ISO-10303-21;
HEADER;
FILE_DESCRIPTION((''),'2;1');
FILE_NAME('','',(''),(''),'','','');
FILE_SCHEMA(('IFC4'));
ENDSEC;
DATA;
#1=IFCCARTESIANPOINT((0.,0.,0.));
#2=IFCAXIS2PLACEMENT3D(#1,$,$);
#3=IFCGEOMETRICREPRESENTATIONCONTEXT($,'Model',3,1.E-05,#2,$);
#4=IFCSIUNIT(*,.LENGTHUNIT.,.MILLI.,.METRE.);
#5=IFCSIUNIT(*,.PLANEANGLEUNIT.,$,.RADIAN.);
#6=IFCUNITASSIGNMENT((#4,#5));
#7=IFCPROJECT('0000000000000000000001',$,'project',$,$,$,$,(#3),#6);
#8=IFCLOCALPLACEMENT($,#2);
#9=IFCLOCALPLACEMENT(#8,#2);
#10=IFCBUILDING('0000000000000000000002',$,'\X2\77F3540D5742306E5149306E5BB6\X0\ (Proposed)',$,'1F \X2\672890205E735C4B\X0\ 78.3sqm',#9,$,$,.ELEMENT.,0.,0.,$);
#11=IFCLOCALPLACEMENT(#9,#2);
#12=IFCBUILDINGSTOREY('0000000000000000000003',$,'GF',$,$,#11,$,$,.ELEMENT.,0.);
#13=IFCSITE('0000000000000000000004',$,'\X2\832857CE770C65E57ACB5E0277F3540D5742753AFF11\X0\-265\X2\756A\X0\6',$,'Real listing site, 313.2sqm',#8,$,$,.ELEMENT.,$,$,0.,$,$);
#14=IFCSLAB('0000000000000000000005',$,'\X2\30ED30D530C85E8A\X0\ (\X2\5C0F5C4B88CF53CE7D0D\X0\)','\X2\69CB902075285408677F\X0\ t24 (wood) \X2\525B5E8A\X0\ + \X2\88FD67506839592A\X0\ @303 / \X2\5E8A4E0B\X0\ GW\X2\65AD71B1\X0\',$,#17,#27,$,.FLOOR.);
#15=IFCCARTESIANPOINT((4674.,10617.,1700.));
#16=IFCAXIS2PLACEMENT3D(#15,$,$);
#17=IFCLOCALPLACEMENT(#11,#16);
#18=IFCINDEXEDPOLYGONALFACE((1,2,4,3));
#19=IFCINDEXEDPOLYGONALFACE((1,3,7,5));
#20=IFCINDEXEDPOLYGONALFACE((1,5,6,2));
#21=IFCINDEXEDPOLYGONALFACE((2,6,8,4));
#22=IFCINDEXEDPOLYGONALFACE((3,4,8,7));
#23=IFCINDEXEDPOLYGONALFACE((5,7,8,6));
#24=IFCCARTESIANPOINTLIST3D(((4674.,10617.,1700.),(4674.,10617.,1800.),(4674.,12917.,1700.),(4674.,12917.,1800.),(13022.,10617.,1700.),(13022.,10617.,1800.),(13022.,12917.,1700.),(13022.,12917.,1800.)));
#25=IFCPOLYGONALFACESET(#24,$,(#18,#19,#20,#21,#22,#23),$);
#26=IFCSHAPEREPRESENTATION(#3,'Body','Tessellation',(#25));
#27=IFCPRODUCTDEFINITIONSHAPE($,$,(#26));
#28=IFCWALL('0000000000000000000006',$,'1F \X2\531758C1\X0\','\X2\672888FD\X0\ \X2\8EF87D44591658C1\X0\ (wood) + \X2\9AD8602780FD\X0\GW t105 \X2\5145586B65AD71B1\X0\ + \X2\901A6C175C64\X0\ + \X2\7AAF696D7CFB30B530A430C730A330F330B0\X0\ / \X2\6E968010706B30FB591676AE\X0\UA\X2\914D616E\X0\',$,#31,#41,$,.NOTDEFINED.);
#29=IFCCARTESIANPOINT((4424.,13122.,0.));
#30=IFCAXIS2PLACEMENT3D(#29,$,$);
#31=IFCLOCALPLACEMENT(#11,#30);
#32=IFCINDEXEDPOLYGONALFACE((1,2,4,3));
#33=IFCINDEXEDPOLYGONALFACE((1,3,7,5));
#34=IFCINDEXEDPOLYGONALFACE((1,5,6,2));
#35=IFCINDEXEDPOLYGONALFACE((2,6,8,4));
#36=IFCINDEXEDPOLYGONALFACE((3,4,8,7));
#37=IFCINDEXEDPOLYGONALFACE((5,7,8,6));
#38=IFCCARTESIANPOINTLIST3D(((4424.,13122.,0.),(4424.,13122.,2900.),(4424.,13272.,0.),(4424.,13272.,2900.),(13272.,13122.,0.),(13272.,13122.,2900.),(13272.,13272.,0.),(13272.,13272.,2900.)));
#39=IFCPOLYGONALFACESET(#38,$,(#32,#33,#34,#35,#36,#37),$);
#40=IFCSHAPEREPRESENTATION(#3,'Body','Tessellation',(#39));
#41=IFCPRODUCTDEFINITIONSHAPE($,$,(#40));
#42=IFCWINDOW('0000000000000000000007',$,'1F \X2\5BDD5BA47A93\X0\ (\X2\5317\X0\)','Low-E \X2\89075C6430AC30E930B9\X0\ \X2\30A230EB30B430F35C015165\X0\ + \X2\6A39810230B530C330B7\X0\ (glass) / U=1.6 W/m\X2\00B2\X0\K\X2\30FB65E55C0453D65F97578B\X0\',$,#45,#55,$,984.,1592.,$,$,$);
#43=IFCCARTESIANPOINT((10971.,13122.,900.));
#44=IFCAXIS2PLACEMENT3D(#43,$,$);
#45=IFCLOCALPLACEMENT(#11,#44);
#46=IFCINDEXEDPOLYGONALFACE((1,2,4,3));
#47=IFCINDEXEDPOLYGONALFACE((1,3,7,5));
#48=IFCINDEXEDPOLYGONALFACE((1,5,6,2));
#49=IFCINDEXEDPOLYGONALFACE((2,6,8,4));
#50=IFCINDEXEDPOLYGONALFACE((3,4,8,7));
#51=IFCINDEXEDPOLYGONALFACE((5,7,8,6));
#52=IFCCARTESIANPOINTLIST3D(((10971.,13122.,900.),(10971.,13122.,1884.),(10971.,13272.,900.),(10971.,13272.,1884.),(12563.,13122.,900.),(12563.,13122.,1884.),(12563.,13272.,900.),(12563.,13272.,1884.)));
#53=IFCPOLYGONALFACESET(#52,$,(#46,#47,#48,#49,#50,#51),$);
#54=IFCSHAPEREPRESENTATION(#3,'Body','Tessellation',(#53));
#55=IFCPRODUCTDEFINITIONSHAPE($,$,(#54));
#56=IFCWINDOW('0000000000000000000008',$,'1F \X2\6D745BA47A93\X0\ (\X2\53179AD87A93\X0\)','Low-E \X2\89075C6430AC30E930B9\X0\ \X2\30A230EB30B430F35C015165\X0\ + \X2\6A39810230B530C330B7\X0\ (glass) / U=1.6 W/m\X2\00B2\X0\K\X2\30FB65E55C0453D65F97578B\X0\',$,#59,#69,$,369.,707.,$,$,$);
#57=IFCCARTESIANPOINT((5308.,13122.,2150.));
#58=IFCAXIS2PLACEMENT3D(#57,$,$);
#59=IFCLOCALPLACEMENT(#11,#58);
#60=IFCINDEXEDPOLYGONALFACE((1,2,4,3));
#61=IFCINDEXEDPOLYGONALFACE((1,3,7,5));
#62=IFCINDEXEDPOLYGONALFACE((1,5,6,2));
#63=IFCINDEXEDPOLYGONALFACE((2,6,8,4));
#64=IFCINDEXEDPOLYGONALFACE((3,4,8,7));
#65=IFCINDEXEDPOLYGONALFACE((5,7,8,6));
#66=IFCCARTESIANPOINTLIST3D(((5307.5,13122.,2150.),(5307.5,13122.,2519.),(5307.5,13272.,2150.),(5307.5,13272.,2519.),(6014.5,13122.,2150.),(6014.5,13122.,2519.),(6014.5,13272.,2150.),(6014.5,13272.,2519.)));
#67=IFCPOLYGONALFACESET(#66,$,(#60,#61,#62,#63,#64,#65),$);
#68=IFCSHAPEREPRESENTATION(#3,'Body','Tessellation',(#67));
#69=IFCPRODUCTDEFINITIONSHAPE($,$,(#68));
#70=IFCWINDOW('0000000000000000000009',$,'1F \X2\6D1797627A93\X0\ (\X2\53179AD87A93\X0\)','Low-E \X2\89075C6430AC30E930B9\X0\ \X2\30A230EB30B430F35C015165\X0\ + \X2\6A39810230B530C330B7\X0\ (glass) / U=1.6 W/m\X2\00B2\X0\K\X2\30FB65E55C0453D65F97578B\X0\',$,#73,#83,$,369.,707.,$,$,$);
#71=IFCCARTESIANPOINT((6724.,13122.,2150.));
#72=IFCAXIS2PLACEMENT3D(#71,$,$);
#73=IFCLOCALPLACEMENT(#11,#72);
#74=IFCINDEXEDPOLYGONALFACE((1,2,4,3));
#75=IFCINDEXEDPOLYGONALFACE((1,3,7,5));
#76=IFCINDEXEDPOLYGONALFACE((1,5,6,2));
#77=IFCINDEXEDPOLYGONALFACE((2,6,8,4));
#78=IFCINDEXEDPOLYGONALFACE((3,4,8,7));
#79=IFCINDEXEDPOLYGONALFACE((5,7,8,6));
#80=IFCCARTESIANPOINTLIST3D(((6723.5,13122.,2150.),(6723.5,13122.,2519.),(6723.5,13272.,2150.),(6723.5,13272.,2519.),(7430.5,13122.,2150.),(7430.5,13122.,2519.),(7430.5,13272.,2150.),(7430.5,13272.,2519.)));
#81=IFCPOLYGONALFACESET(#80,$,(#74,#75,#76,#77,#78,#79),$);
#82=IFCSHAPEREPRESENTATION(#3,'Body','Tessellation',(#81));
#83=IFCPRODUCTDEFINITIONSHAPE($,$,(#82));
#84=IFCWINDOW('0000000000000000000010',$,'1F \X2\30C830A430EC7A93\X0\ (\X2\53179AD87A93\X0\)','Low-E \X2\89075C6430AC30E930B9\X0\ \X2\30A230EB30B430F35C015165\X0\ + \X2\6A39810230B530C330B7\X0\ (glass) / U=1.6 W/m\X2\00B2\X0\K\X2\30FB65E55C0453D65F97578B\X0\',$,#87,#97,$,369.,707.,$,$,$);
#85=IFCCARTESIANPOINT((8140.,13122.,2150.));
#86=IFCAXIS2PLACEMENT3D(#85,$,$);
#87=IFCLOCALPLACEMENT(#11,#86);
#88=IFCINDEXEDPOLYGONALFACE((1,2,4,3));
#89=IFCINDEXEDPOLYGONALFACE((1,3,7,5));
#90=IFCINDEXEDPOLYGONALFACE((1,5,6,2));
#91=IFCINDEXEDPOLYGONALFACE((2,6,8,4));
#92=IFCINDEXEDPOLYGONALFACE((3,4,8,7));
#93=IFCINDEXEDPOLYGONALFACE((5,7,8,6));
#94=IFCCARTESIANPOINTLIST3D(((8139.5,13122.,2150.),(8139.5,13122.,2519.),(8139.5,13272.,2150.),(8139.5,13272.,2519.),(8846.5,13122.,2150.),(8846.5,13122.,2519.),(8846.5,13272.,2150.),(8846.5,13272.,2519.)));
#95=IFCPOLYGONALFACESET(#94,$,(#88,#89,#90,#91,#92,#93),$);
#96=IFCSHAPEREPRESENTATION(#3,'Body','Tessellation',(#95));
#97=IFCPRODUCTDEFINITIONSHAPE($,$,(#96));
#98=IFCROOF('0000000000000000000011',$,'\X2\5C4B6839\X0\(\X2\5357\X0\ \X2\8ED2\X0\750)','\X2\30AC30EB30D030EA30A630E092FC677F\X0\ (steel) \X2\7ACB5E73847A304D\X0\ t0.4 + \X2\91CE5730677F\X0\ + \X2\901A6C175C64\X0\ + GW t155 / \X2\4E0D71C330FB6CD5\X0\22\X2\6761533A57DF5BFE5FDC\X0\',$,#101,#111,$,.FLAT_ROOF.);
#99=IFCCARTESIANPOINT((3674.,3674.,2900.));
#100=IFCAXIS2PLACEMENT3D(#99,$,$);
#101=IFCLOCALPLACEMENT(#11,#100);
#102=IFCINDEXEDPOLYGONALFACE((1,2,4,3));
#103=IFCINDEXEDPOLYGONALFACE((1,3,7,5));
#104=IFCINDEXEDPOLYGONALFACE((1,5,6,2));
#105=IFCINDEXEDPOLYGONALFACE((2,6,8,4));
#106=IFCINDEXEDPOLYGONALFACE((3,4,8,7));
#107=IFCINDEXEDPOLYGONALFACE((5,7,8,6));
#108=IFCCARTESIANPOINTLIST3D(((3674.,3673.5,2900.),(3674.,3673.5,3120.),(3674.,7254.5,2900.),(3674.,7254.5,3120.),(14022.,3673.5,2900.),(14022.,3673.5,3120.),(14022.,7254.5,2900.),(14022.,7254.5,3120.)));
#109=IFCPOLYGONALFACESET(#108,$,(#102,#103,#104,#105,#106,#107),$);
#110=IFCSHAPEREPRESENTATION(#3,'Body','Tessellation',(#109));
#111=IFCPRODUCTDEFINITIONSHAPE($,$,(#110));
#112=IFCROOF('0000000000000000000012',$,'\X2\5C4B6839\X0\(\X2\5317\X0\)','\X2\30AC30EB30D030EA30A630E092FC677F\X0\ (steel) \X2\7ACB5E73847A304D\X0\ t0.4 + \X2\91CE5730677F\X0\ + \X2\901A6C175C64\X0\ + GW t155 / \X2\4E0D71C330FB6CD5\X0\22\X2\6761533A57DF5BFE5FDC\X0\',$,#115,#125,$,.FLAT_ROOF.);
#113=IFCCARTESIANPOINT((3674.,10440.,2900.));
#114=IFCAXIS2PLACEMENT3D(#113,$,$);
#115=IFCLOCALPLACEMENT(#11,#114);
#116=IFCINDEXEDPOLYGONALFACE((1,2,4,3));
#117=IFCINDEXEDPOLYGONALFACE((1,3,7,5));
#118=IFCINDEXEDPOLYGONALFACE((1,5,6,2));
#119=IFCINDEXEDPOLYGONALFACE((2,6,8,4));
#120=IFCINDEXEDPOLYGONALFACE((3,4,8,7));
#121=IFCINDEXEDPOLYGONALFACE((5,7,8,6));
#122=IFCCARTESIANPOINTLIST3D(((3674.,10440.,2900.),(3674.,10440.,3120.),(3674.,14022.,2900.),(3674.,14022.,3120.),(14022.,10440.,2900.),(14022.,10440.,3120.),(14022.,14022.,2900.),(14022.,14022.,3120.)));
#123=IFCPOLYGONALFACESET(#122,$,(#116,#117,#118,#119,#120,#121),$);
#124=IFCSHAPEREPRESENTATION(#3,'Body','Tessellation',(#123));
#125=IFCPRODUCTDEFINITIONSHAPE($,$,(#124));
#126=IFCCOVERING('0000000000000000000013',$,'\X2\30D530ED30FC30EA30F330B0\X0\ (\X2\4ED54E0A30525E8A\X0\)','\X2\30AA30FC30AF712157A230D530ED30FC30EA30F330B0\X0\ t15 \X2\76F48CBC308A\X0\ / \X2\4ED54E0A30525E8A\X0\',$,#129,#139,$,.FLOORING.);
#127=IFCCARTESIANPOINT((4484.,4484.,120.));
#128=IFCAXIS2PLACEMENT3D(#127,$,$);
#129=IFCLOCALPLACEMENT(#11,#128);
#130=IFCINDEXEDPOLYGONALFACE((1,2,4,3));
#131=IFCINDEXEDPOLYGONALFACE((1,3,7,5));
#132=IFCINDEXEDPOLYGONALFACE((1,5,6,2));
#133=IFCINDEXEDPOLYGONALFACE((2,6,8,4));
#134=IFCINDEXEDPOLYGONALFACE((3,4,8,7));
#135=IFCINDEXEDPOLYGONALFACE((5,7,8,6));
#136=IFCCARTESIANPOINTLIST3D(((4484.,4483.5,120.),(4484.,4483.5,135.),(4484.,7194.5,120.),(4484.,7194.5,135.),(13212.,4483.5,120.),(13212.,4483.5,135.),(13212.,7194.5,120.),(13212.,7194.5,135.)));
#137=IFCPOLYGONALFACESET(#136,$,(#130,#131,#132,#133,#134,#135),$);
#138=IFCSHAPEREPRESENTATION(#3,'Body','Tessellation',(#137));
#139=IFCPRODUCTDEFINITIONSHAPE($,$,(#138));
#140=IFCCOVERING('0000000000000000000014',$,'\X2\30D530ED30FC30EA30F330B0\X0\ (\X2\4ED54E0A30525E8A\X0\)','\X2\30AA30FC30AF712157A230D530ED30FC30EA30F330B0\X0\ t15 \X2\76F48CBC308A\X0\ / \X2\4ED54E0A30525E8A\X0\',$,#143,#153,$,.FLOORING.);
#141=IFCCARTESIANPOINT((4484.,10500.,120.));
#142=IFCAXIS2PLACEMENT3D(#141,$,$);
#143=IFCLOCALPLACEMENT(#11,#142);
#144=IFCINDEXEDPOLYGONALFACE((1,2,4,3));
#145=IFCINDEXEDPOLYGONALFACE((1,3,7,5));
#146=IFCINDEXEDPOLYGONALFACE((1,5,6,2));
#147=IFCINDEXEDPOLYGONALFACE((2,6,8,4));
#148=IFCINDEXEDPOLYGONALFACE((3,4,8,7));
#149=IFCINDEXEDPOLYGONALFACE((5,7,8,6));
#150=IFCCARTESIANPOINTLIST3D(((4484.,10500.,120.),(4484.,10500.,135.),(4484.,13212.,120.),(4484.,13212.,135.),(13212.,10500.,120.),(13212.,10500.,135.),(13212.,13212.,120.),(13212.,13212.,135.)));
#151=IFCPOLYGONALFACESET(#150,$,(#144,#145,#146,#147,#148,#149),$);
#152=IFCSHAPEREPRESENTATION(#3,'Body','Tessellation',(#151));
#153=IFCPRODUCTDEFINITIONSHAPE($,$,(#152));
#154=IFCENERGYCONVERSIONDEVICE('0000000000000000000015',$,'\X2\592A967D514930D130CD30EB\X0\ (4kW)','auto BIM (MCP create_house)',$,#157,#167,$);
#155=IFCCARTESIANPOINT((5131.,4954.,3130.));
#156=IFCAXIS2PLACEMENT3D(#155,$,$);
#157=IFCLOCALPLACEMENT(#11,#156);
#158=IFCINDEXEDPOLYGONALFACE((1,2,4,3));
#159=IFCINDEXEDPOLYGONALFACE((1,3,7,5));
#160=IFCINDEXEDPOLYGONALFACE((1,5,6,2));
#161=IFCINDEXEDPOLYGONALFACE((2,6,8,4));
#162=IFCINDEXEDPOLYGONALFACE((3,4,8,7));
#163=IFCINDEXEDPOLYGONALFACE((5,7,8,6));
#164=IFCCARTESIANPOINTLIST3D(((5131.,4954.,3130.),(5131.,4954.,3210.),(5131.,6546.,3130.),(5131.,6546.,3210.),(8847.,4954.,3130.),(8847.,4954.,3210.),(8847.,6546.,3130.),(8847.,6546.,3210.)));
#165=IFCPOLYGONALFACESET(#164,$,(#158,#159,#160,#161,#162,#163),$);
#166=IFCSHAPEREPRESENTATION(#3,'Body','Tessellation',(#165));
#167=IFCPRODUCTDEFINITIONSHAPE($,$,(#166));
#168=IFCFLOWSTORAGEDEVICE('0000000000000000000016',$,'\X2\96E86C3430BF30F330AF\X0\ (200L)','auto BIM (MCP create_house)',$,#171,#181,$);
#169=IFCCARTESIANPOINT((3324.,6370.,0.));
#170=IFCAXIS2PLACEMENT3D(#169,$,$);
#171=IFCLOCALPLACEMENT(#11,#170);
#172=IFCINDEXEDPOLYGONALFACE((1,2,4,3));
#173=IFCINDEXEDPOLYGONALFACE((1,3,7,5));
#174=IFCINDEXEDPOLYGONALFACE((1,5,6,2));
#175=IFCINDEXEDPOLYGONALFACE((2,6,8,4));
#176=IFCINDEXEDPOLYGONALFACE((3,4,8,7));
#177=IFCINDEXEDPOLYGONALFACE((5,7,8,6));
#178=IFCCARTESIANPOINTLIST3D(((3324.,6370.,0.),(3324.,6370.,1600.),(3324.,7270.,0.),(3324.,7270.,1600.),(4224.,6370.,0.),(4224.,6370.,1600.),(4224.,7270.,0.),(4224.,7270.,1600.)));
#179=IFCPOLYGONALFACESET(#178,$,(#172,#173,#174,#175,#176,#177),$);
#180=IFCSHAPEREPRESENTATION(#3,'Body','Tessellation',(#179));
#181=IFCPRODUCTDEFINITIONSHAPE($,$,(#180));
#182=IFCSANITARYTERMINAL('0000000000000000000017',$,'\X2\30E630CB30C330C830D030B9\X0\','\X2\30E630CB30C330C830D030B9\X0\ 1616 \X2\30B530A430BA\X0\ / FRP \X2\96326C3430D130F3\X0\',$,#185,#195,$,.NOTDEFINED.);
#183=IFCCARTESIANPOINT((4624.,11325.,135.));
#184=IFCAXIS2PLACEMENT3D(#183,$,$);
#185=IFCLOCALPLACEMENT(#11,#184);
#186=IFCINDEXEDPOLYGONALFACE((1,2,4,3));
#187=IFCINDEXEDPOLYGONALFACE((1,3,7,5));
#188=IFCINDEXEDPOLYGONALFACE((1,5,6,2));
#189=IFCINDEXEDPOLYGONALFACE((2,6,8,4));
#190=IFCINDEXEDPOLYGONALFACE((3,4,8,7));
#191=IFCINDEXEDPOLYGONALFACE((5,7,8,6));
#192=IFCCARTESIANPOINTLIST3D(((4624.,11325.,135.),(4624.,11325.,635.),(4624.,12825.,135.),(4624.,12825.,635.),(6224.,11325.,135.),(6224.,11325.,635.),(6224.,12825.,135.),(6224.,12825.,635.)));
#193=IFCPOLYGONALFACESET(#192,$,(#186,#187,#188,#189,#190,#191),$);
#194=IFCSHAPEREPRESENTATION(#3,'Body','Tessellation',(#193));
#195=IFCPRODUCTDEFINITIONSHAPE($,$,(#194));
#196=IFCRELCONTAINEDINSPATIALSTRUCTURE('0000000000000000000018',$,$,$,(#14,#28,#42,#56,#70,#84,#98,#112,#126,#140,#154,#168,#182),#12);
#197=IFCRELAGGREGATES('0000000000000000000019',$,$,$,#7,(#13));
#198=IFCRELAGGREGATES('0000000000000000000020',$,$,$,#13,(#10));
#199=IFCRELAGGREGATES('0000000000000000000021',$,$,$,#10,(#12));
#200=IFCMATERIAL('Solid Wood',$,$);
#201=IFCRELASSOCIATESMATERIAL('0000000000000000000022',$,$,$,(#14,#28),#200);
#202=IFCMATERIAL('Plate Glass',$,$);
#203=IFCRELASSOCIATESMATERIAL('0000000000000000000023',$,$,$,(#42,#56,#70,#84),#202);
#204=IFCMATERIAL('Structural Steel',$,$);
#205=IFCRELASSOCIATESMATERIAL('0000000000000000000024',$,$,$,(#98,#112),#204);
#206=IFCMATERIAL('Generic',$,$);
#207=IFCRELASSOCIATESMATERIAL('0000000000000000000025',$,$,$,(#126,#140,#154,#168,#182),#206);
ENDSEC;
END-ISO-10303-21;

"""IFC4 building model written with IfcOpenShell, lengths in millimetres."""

from ifc_helpers import new_model, si_unit, frame, frame_2d, origin, place, context, project, spatial, rectangle, extrude, material, element, fill, save


model = new_model("IFC4")

# Units and contexts
model_context = context("Model", 3, precision=1e-05, world=origin())
ifc_project = project(units=[si_unit("LENGTHUNIT", "METRE", prefix="MILLI"), si_unit("PLANEANGLEUNIT", "RADIAN")], contexts=[model_context])

# Site, building, storey
site_placement = place(None, origin())
site = spatial("IfcSite", under=ifc_project, at=site_placement, Name="茨城県日立市石名坂町１-265番6", ObjectType="Real listing site, 313.2sqm", CompositionType="ELEMENT", RefElevation=0.0)
building_placement = place(site_placement, origin())
building = spatial("IfcBuilding", under=site, at=building_placement, Name="石名坂の光の家 (Proposed)", ObjectType="1F 木造平屋 78.3sqm", CompositionType="ELEMENT", ElevationOfRefHeight=0.0, ElevationOfTerrain=0.0)
storey_placement = place(building_placement, origin())
storey = spatial("IfcBuildingStorey", under=building, at=storey_placement, Name="GF", CompositionType="ELEMENT", Elevation=0.0)

# Slab
ifc_material_1 = material(Name="Solid Wood")
slab_1_placement = place(storey_placement, frame((4674.0, 10617.0, 1700.0)))
element("IfcSlab", 1, at=slab_1_placement, inside=storey, material=ifc_material_1, Name="ロフト床 (小屋裏収納)", Description="構造用合板 t24 (wood) 剛床 + 製材根太 @303 / 床下 GW断熱", PredefinedType="FLOOR", context=model_context, shape_type="SweptSolid", body=[
    extrude(rectangle(XDim=8348.0, YDim=2300.0, at=frame_2d((4174.0, 1150.0))), frame((4674.0, 10617.0, 1700.0)), (0.0, 0.0, 1.0), 100.0),
])

# Shared definitions
ifc_material_2 = material(Name="Plate Glass")

# Wall, openings, windows
wall_1_placement = place(storey_placement, frame((4424.0, 13122.0, 0.0)))
wall_1 = element("IfcWall", 2, at=wall_1_placement, inside=storey, material=ifc_material_1, Name="1F 北壁", Description="木製 軸組外壁 (wood) + 高性能GW t105 充填断熱 + 通気層 + 窯業系サイディング / 準耐火・外皮UA配慮", PredefinedType="NOTDEFINED", context=model_context, shape_type="SweptSolid", body=[
    extrude(rectangle(XDim=8848.0, YDim=150.0, at=frame_2d((4424.0, 75.0))), frame((4424.0, 13122.0, 0.0)), (0.0, 0.0, 1.0), 2900.0),
])
opening_1_placement = place(storey_placement, frame((10971.0, 13122.0, 900.0)))
opening_1 = element("IfcOpeningElement", 3, at=opening_1_placement, cuts=wall_1, PredefinedType="NOTDEFINED", context=model_context, shape_type="SweptSolid", body=[
    extrude(rectangle(XDim=1592.0, YDim=150.0, at=frame_2d((796.0, 75.0))), frame((10971.0, 13122.0, 900.0)), (0.0, 0.0, 1.0), 984.0),
])
opening_2_placement = place(storey_placement, frame((5308.0, 13122.0, 2150.0)))
opening_2 = element("IfcOpeningElement", 4, at=opening_2_placement, cuts=wall_1, PredefinedType="NOTDEFINED", context=model_context, shape_type="SweptSolid", body=[
    extrude(rectangle(XDim=707.0, YDim=150.0, at=frame_2d((353.0, 75.0))), frame((5308.0, 13122.0, 2150.0)), (0.0, 0.0, 1.0), 369.0),
])
opening_3_placement = place(storey_placement, frame((6724.0, 13122.0, 2150.0)))
opening_3 = element("IfcOpeningElement", 5, at=opening_3_placement, cuts=wall_1, PredefinedType="NOTDEFINED", context=model_context, shape_type="SweptSolid", body=[
    extrude(rectangle(XDim=707.0, YDim=150.0, at=frame_2d((353.0, 75.0))), frame((6724.0, 13122.0, 2150.0)), (0.0, 0.0, 1.0), 369.0),
])
opening_4_placement = place(storey_placement, frame((8140.0, 13122.0, 2150.0)))
opening_4 = element("IfcOpeningElement", 6, at=opening_4_placement, cuts=wall_1, PredefinedType="NOTDEFINED", context=model_context, shape_type="SweptSolid", body=[
    extrude(rectangle(XDim=707.0, YDim=150.0, at=frame_2d((353.0, 75.0))), frame((8140.0, 13122.0, 2150.0)), (0.0, 0.0, 1.0), 369.0),
])
window_1_placement = place(storey_placement, frame((10971.0, 13122.0, 900.0)))
window_1 = element("IfcWindow", 7, at=window_1_placement, inside=storey, material=ifc_material_2, Name="1F 寝室窓 (北)", Description="Low-E 複層ガラス アルゴン封入 + 樹脂サッシ (glass) / U=1.6 W/m²K・日射取得型", OverallHeight=984.0, OverallWidth=1592.0, context=model_context, shape_type="SweptSolid", body=[
    extrude(rectangle(XDim=1592.0, YDim=150.0, at=frame_2d((796.0, 75.0))), frame((10971.0, 13122.0, 900.0)), (0.0, 0.0, 1.0), 984.0),
])
fill(opening_1, window_1)
window_2_placement = place(storey_placement, frame((5308.0, 13122.0, 2150.0)))
window_2 = element("IfcWindow", 8, at=window_2_placement, inside=storey, material=ifc_material_2, Name="1F 浴室窓 (北高窓)", Description="Low-E 複層ガラス アルゴン封入 + 樹脂サッシ (glass) / U=1.6 W/m²K・日射取得型", OverallHeight=369.0, OverallWidth=707.0, context=model_context, shape_type="SweptSolid", body=[
    extrude(rectangle(XDim=707.0, YDim=150.0, at=frame_2d((353.0, 75.0))), frame((5308.0, 13122.0, 2150.0)), (0.0, 0.0, 1.0), 369.0),
])
fill(opening_2, window_2)
window_3_placement = place(storey_placement, frame((6724.0, 13122.0, 2150.0)))
window_3 = element("IfcWindow", 9, at=window_3_placement, inside=storey, material=ifc_material_2, Name="1F 洗面窓 (北高窓)", Description="Low-E 複層ガラス アルゴン封入 + 樹脂サッシ (glass) / U=1.6 W/m²K・日射取得型", OverallHeight=369.0, OverallWidth=707.0, context=model_context, shape_type="SweptSolid", body=[
    extrude(rectangle(XDim=707.0, YDim=150.0, at=frame_2d((353.0, 75.0))), frame((6724.0, 13122.0, 2150.0)), (0.0, 0.0, 1.0), 369.0),
])
fill(opening_3, window_3)
window_4_placement = place(storey_placement, frame((8140.0, 13122.0, 2150.0)))
window_4 = element("IfcWindow", 10, at=window_4_placement, inside=storey, material=ifc_material_2, Name="1F トイレ窓 (北高窓)", Description="Low-E 複層ガラス アルゴン封入 + 樹脂サッシ (glass) / U=1.6 W/m²K・日射取得型", OverallHeight=369.0, OverallWidth=707.0, context=model_context, shape_type="SweptSolid", body=[
    extrude(rectangle(XDim=707.0, YDim=150.0, at=frame_2d((353.0, 75.0))), frame((8140.0, 13122.0, 2150.0)), (0.0, 0.0, 1.0), 369.0),
])
fill(opening_4, window_4)

# Roofs
ifc_material_3 = material(Name="Structural Steel")
roof_1_placement = place(storey_placement, frame((3674.0, 3674.0, 2900.0)))
element("IfcRoof", 11, at=roof_1_placement, inside=storey, material=ifc_material_3, Name="屋根(南 軒750)", Description="ガルバリウム鋼板 (steel) 立平葺き t0.4 + 野地板 + 通気層 + GW t155 / 不燃・法22条区域対応", PredefinedType="FLAT_ROOF", context=model_context, shape_type="SweptSolid", body=[
    extrude(rectangle(XDim=10348.0, YDim=3581.0, at=frame_2d((5174.0, 1790.0))), frame((3674.0, 3674.0, 2900.0)), (0.0, 0.0, 1.0), 220.0),
])
roof_2_placement = place(storey_placement, frame((3674.0, 10440.0, 2900.0)))
element("IfcRoof", 12, at=roof_2_placement, inside=storey, material=ifc_material_3, Name="屋根(北)", Description="ガルバリウム鋼板 (steel) 立平葺き t0.4 + 野地板 + 通気層 + GW t155 / 不燃・法22条区域対応", PredefinedType="FLAT_ROOF", context=model_context, shape_type="SweptSolid", body=[
    extrude(rectangle(XDim=10348.0, YDim=3582.0, at=frame_2d((5174.0, 1791.0))), frame((3674.0, 10440.0, 2900.0)), (0.0, 0.0, 1.0), 220.0),
])

# Coverings
ifc_material_4 = material(Name="Generic")
covering_1_placement = place(storey_placement, frame((4484.0, 4484.0, 120.0)))
element("IfcCovering", 13, at=covering_1_placement, inside=storey, material=ifc_material_4, Name="フローリング (仕上げ床)", Description="オーク無垢フローリング t15 直貼り / 仕上げ床", PredefinedType="FLOORING", context=model_context, shape_type="SweptSolid", body=[
    extrude(rectangle(XDim=8728.0, YDim=2711.0, at=frame_2d((4364.0, 1355.0))), frame((4484.0, 4484.0, 120.0)), (0.0, 0.0, 1.0), 15.0),
])
covering_2_placement = place(storey_placement, frame((4484.0, 10500.0, 120.0)))
element("IfcCovering", 14, at=covering_2_placement, inside=storey, material=ifc_material_4, Name="フローリング (仕上げ床)", Description="オーク無垢フローリング t15 直貼り / 仕上げ床", PredefinedType="FLOORING", context=model_context, shape_type="SweptSolid", body=[
    extrude(rectangle(XDim=8728.0, YDim=2712.0, at=frame_2d((4364.0, 1356.0))), frame((4484.0, 10500.0, 120.0)), (0.0, 0.0, 1.0), 15.0),
])

# Energy conversion device
energy_conversion_device_placement = place(storey_placement, frame((5131.0, 4954.0, 3130.0)))
element("IfcEnergyConversionDevice", 15, at=energy_conversion_device_placement, inside=storey, material=ifc_material_4, Name="太陽光パネル (4kW)", Description="auto BIM (MCP create_house)", context=model_context, shape_type="SweptSolid", body=[
    extrude(rectangle(XDim=3716.0, YDim=1592.0, at=frame_2d((1858.0, 796.0))), frame((5131.0, 4954.0, 3130.0)), (0.0, 0.0, 1.0), 80.0),
])

# Flow storage device
flow_storage_device_placement = place(storey_placement, frame((3324.0, 6370.0, 0.0)))
element("IfcFlowStorageDevice", 16, at=flow_storage_device_placement, inside=storey, material=ifc_material_4, Name="雨水タンク (200L)", Description="auto BIM (MCP create_house)", context=model_context, shape_type="SweptSolid", body=[
    extrude(rectangle(XDim=900.0, YDim=900.0, at=frame_2d((450.0, 450.0))), frame((3324.0, 6370.0, 0.0)), (0.0, 0.0, 1.0), 1600.0),
])

# Sanitary terminal
sanitary_terminal_placement = place(storey_placement, frame((4624.0, 11325.0, 135.0)))
element("IfcSanitaryTerminal", 17, at=sanitary_terminal_placement, inside=storey, material=ifc_material_4, Name="ユニットバス", Description="ユニットバス 1616 サイズ / FRP 防水パン", PredefinedType="NOTDEFINED", context=model_context, shape_type="SweptSolid", body=[
    extrude(rectangle(XDim=1600.0, YDim=1500.0, at=frame_2d((800.0, 750.0))), frame((4624.0, 11325.0, 135.0)), (0.0, 0.0, 1.0), 500.0),
])

save(model, "model.ifc")
